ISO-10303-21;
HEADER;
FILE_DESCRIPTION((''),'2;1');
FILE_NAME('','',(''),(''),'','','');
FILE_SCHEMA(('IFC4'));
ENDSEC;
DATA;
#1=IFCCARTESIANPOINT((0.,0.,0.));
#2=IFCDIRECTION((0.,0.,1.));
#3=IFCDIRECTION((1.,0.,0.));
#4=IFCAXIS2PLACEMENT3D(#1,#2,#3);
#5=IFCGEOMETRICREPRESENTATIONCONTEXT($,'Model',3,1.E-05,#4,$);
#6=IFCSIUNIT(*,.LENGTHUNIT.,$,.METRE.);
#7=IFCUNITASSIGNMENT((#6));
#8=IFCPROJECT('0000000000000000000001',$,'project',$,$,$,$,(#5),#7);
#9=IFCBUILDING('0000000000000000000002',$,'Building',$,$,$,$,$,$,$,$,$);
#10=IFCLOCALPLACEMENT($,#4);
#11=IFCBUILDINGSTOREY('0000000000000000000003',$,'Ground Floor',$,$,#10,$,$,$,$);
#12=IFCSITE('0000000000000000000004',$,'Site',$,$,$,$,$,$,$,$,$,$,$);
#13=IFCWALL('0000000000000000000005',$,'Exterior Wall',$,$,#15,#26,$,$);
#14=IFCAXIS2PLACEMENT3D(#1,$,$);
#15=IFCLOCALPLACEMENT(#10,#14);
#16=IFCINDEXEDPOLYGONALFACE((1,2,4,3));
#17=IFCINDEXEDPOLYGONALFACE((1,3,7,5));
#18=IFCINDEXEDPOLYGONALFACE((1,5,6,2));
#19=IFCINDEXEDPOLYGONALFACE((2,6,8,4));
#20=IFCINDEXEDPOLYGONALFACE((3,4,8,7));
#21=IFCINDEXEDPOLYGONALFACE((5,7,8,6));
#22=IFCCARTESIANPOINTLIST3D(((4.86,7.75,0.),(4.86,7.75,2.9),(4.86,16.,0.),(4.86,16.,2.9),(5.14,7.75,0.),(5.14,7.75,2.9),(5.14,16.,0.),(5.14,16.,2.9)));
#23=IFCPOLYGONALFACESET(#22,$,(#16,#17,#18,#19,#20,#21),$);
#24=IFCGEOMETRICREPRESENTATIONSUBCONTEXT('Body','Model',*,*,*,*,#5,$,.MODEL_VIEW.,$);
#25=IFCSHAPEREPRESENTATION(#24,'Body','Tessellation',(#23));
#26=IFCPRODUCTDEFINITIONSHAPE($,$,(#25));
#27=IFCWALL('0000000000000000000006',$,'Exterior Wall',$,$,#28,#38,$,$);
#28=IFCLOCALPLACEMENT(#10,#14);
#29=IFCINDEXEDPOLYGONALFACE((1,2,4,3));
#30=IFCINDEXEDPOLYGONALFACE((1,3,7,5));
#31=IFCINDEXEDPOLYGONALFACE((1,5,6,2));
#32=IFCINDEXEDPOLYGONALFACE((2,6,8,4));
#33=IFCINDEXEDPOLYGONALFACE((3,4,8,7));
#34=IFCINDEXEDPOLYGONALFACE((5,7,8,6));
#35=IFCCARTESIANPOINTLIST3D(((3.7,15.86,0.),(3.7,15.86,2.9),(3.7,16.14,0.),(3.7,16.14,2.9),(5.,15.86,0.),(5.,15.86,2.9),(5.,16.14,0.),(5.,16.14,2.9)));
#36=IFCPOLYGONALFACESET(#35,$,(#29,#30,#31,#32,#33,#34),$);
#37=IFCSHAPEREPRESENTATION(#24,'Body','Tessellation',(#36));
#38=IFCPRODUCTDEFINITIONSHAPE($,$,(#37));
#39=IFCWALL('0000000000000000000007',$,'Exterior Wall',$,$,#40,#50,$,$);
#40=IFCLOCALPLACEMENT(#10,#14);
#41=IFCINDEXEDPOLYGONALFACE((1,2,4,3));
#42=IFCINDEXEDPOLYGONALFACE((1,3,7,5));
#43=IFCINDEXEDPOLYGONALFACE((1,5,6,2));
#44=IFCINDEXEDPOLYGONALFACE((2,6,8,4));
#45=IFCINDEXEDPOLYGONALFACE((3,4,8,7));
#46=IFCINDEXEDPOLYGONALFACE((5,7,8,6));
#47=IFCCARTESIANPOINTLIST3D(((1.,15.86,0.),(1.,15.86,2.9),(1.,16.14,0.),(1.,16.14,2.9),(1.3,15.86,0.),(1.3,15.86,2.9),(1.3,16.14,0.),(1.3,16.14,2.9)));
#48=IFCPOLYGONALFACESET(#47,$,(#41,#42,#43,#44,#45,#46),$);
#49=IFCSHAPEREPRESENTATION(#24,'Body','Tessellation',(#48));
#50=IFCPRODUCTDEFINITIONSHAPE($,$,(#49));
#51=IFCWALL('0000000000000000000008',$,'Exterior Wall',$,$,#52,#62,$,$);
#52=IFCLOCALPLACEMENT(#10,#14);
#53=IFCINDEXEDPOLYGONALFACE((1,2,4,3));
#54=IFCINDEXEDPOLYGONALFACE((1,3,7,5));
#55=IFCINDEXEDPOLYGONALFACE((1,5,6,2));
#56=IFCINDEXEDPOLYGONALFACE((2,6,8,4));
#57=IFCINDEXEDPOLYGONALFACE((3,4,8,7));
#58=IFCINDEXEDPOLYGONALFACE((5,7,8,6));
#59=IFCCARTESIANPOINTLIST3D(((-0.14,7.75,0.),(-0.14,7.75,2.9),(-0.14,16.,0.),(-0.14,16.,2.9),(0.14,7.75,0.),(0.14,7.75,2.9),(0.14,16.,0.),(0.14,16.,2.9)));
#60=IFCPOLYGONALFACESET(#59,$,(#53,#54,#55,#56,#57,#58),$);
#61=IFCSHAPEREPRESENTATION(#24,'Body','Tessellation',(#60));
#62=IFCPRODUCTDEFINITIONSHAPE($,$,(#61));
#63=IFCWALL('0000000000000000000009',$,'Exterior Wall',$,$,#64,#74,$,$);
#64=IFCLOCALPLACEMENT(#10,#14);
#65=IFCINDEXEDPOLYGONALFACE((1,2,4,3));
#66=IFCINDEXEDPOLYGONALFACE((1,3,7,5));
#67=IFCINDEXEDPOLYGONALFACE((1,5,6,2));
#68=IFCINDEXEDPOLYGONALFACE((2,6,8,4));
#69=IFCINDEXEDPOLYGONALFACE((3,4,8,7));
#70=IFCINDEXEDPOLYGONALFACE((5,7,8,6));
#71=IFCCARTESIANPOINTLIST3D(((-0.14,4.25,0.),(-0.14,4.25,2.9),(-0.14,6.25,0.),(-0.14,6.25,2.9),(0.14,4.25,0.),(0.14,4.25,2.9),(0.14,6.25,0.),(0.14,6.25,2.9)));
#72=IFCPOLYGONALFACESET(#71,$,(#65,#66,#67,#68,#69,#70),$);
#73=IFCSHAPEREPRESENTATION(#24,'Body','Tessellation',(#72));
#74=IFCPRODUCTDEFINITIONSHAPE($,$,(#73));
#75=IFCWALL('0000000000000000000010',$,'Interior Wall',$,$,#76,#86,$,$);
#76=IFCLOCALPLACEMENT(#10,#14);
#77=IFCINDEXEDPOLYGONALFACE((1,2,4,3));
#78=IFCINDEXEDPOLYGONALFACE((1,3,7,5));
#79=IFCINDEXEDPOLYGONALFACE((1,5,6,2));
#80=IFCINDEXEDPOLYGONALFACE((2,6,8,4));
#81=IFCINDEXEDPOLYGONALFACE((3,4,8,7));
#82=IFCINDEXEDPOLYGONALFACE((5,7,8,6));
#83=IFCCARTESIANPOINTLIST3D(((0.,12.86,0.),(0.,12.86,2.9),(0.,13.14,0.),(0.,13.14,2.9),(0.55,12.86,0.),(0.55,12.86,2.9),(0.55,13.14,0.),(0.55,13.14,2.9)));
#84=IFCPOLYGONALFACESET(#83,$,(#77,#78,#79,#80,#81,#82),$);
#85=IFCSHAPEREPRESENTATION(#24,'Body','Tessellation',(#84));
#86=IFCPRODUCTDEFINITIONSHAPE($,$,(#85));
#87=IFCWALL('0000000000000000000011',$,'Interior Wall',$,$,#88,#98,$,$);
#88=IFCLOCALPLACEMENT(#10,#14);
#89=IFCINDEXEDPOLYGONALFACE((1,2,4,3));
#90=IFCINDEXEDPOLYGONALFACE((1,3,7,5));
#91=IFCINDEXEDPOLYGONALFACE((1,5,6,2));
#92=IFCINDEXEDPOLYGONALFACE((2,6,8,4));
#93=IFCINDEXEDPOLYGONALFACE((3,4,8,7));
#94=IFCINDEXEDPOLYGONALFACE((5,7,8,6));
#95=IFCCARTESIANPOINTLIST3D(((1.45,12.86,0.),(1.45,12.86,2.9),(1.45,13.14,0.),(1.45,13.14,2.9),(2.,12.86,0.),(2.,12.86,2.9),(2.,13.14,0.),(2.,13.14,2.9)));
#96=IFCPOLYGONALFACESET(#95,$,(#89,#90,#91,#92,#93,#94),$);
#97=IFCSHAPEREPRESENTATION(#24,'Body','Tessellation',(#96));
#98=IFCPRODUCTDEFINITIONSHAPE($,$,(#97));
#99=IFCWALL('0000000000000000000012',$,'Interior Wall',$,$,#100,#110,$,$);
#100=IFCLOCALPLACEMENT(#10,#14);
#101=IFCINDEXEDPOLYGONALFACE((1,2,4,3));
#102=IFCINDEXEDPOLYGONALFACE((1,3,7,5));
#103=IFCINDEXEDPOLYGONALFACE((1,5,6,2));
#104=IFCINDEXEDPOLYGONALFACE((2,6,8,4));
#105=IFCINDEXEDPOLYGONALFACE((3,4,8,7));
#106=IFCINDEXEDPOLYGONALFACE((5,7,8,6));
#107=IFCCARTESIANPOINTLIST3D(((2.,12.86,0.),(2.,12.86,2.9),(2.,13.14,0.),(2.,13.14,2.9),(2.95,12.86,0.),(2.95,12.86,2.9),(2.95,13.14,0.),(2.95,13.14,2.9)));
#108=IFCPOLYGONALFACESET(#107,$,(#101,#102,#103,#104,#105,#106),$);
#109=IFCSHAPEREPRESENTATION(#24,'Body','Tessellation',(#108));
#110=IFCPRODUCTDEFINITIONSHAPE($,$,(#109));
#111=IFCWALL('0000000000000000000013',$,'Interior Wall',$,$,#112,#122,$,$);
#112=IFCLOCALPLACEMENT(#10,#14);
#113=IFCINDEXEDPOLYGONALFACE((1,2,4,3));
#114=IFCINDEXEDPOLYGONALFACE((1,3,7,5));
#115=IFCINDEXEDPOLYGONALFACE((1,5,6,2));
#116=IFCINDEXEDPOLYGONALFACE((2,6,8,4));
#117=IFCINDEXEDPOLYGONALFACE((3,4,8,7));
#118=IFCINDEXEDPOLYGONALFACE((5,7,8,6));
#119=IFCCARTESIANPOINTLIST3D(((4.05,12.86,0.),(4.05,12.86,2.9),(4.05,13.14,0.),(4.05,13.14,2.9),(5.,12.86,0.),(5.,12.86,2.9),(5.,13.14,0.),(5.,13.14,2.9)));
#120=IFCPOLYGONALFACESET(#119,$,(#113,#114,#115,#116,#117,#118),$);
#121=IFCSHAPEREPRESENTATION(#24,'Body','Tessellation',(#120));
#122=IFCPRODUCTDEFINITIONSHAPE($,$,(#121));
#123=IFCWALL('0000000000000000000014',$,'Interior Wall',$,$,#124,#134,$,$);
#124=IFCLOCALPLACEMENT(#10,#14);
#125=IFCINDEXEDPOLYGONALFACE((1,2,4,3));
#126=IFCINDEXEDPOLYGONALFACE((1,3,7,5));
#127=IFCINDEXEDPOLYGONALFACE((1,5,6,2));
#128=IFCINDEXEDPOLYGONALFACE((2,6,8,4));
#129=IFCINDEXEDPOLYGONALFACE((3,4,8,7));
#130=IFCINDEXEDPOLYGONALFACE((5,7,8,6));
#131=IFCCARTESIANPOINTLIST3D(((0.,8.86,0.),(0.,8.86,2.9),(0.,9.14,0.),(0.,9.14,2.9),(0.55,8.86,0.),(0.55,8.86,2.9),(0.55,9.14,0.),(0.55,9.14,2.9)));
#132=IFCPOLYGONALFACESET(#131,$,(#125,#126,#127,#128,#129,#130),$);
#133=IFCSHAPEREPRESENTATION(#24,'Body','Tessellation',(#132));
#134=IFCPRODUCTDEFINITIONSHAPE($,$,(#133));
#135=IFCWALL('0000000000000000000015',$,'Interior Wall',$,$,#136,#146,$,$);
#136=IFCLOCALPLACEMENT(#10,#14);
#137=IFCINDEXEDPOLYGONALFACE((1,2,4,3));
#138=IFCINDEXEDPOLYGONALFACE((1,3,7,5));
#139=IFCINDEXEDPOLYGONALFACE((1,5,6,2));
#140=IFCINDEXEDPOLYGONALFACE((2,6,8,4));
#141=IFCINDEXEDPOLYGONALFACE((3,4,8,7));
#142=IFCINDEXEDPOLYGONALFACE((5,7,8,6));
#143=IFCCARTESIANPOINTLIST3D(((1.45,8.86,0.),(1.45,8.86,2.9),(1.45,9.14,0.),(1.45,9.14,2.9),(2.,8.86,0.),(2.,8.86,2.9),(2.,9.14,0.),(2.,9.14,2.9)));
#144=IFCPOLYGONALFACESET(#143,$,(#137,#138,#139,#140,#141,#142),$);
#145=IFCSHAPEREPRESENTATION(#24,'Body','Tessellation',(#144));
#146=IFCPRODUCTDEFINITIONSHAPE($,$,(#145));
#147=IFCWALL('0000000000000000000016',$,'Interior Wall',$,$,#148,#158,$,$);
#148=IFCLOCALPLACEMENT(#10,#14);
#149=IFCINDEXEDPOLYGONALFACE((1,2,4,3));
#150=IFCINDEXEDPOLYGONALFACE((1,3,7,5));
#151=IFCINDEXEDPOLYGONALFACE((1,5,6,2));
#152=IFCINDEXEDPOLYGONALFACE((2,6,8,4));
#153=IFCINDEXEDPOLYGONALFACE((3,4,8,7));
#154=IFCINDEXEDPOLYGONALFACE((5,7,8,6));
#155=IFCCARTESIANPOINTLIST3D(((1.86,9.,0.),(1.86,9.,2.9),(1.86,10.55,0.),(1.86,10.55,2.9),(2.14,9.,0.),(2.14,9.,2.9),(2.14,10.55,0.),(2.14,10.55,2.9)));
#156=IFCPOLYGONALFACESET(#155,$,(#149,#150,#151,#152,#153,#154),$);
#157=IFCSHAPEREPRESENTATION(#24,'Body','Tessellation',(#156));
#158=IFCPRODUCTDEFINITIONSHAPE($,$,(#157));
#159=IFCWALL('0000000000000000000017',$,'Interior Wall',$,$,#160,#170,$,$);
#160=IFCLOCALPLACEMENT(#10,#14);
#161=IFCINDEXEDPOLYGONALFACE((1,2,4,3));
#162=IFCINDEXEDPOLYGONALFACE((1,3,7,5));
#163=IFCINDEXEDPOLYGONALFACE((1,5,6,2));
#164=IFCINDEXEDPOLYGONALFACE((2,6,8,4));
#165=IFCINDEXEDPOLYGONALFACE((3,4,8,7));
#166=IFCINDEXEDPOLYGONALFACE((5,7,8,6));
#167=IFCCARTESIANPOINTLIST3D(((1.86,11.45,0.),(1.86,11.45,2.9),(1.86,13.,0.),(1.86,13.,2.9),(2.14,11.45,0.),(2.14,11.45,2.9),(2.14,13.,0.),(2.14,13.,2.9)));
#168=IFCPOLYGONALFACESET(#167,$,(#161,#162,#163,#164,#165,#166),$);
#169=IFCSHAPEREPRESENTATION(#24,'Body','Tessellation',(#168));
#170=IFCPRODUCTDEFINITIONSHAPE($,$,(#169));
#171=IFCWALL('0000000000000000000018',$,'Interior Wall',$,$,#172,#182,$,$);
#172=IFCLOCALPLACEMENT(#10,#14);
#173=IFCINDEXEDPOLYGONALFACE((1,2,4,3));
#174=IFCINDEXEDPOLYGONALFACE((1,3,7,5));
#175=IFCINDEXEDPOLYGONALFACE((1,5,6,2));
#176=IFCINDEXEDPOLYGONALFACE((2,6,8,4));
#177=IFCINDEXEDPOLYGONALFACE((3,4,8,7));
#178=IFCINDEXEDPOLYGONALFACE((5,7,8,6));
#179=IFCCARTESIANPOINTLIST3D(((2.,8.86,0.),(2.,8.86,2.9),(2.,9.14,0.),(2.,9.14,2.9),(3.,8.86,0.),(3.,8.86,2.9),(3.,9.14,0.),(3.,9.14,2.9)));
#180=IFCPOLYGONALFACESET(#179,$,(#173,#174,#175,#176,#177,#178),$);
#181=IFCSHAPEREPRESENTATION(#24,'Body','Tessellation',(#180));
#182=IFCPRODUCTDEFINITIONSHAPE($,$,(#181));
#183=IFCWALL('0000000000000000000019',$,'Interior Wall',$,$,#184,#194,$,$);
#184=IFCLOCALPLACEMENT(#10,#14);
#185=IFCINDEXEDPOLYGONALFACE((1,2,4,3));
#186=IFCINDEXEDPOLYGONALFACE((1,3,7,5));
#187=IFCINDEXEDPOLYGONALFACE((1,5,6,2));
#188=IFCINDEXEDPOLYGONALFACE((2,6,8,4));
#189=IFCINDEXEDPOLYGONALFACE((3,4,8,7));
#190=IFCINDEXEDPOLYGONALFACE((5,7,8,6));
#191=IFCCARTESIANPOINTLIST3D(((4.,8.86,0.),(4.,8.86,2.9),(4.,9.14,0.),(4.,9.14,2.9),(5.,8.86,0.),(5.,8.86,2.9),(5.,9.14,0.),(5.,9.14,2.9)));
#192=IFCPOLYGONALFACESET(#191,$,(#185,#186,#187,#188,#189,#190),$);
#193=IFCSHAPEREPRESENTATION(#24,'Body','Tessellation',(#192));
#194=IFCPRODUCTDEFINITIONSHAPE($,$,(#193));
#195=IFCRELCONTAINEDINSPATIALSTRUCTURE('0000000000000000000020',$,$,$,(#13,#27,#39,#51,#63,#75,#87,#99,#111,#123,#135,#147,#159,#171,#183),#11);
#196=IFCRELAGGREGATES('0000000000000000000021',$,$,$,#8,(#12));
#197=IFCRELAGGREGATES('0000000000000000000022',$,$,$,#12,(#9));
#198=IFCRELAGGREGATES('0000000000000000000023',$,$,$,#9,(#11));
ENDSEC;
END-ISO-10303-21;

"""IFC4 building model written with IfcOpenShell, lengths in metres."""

from ifc_helpers import new_model, si_unit, frame, origin_with_axes, place, context, subcontext, project, spatial, indexed_curve, outline, extrude, element, save


model = new_model("IFC4")

# Units and contexts
model_context = context("Model", 3, precision=1e-05, world=origin_with_axes())
body_context = subcontext(model_context, "Body", "Model", "MODEL_VIEW")
ifc_project = project(units=[si_unit("LENGTHUNIT", "METRE")], contexts=[model_context])

# Site, building, storey
site = spatial("IfcSite", under=ifc_project, Name="Site")
building = spatial("IfcBuilding", under=site, Name="Building")
storey_placement = place(None, origin_with_axes())
storey = spatial("IfcBuildingStorey", under=building, at=storey_placement, Name="Ground Floor")

# Walls
wall_1_placement = place(storey_placement, frame((5.0, 7.75, 0.0), z_axis=(0.0, 0.0, 1.0), x_axis=(0.0, 1.0, 0.0)))
element("IfcWall", 1, at=wall_1_placement, inside=storey, Name="Exterior Wall", context=body_context, shape_type="SweptSolid", body=[
    extrude(outline(indexed_curve([(0.0, 0.0), (0.0, 0.28), (8.25, 0.28), (8.25, 0.0), (0.0, 0.0)], self_intersect=False)), frame((0.0, -0.14, 0.0), z_axis=(0.0, 0.0, 1.0), x_axis=(1.0, 0.0, 0.0)), (0.0, 0.0, 1.0), 2.9),
])
wall_2_placement = place(storey_placement, frame((5.0, 16.0, 0.0), z_axis=(0.0, 0.0, 1.0), x_axis=(-1.0, 0.0, 0.0)))
element("IfcWall", 2, at=wall_2_placement, inside=storey, Name="Exterior Wall", context=body_context, shape_type="SweptSolid", body=[
    extrude(outline(indexed_curve([(0.0, 0.0), (0.0, 0.28), (1.3, 0.28), (1.3, 0.0), (0.0, 0.0)], self_intersect=False)), frame((0.0, -0.14, 0.0), z_axis=(0.0, 0.0, 1.0), x_axis=(1.0, 0.0, 0.0)), (0.0, 0.0, 1.0), 2.9),
])
wall_3_placement = place(storey_placement, frame((1.3, 16.0, 0.0), z_axis=(0.0, 0.0, 1.0), x_axis=(-1.0, 0.0, 0.0)))
element("IfcWall", 3, at=wall_3_placement, inside=storey, Name="Exterior Wall", context=body_context, shape_type="SweptSolid", body=[
    extrude(outline(indexed_curve([(0.0, 0.0), (0.0, 0.28), (0.3, 0.28), (0.3, 0.0), (0.0, 0.0)], self_intersect=False)), frame((0.0, -0.14, 0.0), z_axis=(0.0, 0.0, 1.0), x_axis=(1.0, 0.0, 0.0)), (0.0, 0.0, 1.0), 2.9),
])
wall_4_placement = place(storey_placement, frame((0.0, 16.0, 0.0), z_axis=(0.0, 0.0, 1.0), x_axis=(0.0, -1.0, 0.0)))
element("IfcWall", 4, at=wall_4_placement, inside=storey, Name="Exterior Wall", context=body_context, shape_type="SweptSolid", body=[
    extrude(outline(indexed_curve([(0.0, 0.0), (0.0, 0.28), (8.25, 0.28), (8.25, 0.0), (0.0, 0.0)], self_intersect=False)), frame((0.0, -0.14, 0.0), z_axis=(0.0, 0.0, 1.0), x_axis=(1.0, 0.0, 0.0)), (0.0, 0.0, 1.0), 2.9),
])
wall_5_placement = place(storey_placement, frame((0.0, 6.25, 0.0), z_axis=(0.0, 0.0, 1.0), x_axis=(0.0, -1.0, 0.0)))
element("IfcWall", 5, at=wall_5_placement, inside=storey, Name="Exterior Wall", context=body_context, shape_type="SweptSolid", body=[
    extrude(outline(indexed_curve([(0.0, 0.0), (0.0, 0.28), (2.0, 0.28), (2.0, 0.0), (0.0, 0.0)], self_intersect=False)), frame((0.0, -0.14, 0.0), z_axis=(0.0, 0.0, 1.0), x_axis=(1.0, 0.0, 0.0)), (0.0, 0.0, 1.0), 2.9),
])
for number, where, z_axis, x_axis, name in (
    (6, (0.0, 13.0, 0.0), (0.0, 0.0, 1.0), (1.0, 0.0, 0.0), "Interior Wall"),
    (7, (1.45, 13.0, 0.0), (0.0, 0.0, 1.0), (1.0, 0.0, 0.0), "Interior Wall"),
):
    element("IfcWall", number, at=place(storey_placement, frame(where, z_axis=z_axis, x_axis=x_axis)), inside=storey, Name=name, context=body_context, shape_type="SweptSolid", body=[
        extrude(outline(indexed_curve([(0.0, 0.0), (0.0, 0.28), (0.55, 0.28), (0.55, 0.0), (0.0, 0.0)], self_intersect=False)), frame((0.0, -0.14, 0.0), z_axis=(0.0, 0.0, 1.0), x_axis=(1.0, 0.0, 0.0)), (0.0, 0.0, 1.0), 2.9),
    ])
for number, where, z_axis, x_axis, name in (
    (8, (2.0, 13.0, 0.0), (0.0, 0.0, 1.0), (1.0, 0.0, 0.0), "Interior Wall"),
    (9, (4.05, 13.0, 0.0), (0.0, 0.0, 1.0), (1.0, 0.0, 0.0), "Interior Wall"),
):
    element("IfcWall", number, at=place(storey_placement, frame(where, z_axis=z_axis, x_axis=x_axis)), inside=storey, Name=name, context=body_context, shape_type="SweptSolid", body=[
        extrude(outline(indexed_curve([(0.0, 0.0), (0.0, 0.28), (0.95, 0.28), (0.95, 0.0), (0.0, 0.0)], self_intersect=False)), frame((0.0, -0.14, 0.0), z_axis=(0.0, 0.0, 1.0), x_axis=(1.0, 0.0, 0.0)), (0.0, 0.0, 1.0), 2.9),
    ])
for number, where, z_axis, x_axis, name in (
    (10, (0.0, 9.0, 0.0), (0.0, 0.0, 1.0), (1.0, 0.0, 0.0), "Interior Wall"),
    (11, (1.45, 9.0, 0.0), (0.0, 0.0, 1.0), (1.0, 0.0, 0.0), "Interior Wall"),
):
    element("IfcWall", number, at=place(storey_placement, frame(where, z_axis=z_axis, x_axis=x_axis)), inside=storey, Name=name, context=body_context, shape_type="SweptSolid", body=[
        extrude(outline(indexed_curve([(0.0, 0.0), (0.0, 0.28), (0.55, 0.28), (0.55, 0.0), (0.0, 0.0)], self_intersect=False)), frame((0.0, -0.14, 0.0), z_axis=(0.0, 0.0, 1.0), x_axis=(1.0, 0.0, 0.0)), (0.0, 0.0, 1.0), 2.9),
    ])
for number, where, z_axis, x_axis, name in (
    (12, (2.0, 9.0, 0.0), (0.0, 0.0, 1.0), (0.0, 1.0, 0.0), "Interior Wall"),
    (13, (2.0, 11.45, 0.0), (0.0, 0.0, 1.0), (0.0, 1.0, 0.0), "Interior Wall"),
):
    element("IfcWall", number, at=place(storey_placement, frame(where, z_axis=z_axis, x_axis=x_axis)), inside=storey, Name=name, context=body_context, shape_type="SweptSolid", body=[
        extrude(outline(indexed_curve([(0.0, 0.0), (0.0, 0.28), (1.55, 0.28), (1.55, 0.0), (0.0, 0.0)], self_intersect=False)), frame((0.0, -0.14, 0.0), z_axis=(0.0, 0.0, 1.0), x_axis=(1.0, 0.0, 0.0)), (0.0, 0.0, 1.0), 2.9),
    ])
for number, where, z_axis, x_axis, name in (
    (14, (2.0, 9.0, 0.0), (0.0, 0.0, 1.0), (1.0, 0.0, 0.0), "Interior Wall"),
    (15, (4.0, 9.0, 0.0), (0.0, 0.0, 1.0), (1.0, 0.0, 0.0), "Interior Wall"),
):
    element("IfcWall", number, at=place(storey_placement, frame(where, z_axis=z_axis, x_axis=x_axis)), inside=storey, Name=name, context=body_context, shape_type="SweptSolid", body=[
        extrude(outline(indexed_curve([(0.0, 0.0), (0.0, 0.28), (1.0, 0.28), (1.0, 0.0), (0.0, 0.0)], self_intersect=False)), frame((0.0, -0.14, 0.0), z_axis=(0.0, 0.0, 1.0), x_axis=(1.0, 0.0, 0.0)), (0.0, 0.0, 1.0), 2.9),
    ])

save(model, "model.ifc")
